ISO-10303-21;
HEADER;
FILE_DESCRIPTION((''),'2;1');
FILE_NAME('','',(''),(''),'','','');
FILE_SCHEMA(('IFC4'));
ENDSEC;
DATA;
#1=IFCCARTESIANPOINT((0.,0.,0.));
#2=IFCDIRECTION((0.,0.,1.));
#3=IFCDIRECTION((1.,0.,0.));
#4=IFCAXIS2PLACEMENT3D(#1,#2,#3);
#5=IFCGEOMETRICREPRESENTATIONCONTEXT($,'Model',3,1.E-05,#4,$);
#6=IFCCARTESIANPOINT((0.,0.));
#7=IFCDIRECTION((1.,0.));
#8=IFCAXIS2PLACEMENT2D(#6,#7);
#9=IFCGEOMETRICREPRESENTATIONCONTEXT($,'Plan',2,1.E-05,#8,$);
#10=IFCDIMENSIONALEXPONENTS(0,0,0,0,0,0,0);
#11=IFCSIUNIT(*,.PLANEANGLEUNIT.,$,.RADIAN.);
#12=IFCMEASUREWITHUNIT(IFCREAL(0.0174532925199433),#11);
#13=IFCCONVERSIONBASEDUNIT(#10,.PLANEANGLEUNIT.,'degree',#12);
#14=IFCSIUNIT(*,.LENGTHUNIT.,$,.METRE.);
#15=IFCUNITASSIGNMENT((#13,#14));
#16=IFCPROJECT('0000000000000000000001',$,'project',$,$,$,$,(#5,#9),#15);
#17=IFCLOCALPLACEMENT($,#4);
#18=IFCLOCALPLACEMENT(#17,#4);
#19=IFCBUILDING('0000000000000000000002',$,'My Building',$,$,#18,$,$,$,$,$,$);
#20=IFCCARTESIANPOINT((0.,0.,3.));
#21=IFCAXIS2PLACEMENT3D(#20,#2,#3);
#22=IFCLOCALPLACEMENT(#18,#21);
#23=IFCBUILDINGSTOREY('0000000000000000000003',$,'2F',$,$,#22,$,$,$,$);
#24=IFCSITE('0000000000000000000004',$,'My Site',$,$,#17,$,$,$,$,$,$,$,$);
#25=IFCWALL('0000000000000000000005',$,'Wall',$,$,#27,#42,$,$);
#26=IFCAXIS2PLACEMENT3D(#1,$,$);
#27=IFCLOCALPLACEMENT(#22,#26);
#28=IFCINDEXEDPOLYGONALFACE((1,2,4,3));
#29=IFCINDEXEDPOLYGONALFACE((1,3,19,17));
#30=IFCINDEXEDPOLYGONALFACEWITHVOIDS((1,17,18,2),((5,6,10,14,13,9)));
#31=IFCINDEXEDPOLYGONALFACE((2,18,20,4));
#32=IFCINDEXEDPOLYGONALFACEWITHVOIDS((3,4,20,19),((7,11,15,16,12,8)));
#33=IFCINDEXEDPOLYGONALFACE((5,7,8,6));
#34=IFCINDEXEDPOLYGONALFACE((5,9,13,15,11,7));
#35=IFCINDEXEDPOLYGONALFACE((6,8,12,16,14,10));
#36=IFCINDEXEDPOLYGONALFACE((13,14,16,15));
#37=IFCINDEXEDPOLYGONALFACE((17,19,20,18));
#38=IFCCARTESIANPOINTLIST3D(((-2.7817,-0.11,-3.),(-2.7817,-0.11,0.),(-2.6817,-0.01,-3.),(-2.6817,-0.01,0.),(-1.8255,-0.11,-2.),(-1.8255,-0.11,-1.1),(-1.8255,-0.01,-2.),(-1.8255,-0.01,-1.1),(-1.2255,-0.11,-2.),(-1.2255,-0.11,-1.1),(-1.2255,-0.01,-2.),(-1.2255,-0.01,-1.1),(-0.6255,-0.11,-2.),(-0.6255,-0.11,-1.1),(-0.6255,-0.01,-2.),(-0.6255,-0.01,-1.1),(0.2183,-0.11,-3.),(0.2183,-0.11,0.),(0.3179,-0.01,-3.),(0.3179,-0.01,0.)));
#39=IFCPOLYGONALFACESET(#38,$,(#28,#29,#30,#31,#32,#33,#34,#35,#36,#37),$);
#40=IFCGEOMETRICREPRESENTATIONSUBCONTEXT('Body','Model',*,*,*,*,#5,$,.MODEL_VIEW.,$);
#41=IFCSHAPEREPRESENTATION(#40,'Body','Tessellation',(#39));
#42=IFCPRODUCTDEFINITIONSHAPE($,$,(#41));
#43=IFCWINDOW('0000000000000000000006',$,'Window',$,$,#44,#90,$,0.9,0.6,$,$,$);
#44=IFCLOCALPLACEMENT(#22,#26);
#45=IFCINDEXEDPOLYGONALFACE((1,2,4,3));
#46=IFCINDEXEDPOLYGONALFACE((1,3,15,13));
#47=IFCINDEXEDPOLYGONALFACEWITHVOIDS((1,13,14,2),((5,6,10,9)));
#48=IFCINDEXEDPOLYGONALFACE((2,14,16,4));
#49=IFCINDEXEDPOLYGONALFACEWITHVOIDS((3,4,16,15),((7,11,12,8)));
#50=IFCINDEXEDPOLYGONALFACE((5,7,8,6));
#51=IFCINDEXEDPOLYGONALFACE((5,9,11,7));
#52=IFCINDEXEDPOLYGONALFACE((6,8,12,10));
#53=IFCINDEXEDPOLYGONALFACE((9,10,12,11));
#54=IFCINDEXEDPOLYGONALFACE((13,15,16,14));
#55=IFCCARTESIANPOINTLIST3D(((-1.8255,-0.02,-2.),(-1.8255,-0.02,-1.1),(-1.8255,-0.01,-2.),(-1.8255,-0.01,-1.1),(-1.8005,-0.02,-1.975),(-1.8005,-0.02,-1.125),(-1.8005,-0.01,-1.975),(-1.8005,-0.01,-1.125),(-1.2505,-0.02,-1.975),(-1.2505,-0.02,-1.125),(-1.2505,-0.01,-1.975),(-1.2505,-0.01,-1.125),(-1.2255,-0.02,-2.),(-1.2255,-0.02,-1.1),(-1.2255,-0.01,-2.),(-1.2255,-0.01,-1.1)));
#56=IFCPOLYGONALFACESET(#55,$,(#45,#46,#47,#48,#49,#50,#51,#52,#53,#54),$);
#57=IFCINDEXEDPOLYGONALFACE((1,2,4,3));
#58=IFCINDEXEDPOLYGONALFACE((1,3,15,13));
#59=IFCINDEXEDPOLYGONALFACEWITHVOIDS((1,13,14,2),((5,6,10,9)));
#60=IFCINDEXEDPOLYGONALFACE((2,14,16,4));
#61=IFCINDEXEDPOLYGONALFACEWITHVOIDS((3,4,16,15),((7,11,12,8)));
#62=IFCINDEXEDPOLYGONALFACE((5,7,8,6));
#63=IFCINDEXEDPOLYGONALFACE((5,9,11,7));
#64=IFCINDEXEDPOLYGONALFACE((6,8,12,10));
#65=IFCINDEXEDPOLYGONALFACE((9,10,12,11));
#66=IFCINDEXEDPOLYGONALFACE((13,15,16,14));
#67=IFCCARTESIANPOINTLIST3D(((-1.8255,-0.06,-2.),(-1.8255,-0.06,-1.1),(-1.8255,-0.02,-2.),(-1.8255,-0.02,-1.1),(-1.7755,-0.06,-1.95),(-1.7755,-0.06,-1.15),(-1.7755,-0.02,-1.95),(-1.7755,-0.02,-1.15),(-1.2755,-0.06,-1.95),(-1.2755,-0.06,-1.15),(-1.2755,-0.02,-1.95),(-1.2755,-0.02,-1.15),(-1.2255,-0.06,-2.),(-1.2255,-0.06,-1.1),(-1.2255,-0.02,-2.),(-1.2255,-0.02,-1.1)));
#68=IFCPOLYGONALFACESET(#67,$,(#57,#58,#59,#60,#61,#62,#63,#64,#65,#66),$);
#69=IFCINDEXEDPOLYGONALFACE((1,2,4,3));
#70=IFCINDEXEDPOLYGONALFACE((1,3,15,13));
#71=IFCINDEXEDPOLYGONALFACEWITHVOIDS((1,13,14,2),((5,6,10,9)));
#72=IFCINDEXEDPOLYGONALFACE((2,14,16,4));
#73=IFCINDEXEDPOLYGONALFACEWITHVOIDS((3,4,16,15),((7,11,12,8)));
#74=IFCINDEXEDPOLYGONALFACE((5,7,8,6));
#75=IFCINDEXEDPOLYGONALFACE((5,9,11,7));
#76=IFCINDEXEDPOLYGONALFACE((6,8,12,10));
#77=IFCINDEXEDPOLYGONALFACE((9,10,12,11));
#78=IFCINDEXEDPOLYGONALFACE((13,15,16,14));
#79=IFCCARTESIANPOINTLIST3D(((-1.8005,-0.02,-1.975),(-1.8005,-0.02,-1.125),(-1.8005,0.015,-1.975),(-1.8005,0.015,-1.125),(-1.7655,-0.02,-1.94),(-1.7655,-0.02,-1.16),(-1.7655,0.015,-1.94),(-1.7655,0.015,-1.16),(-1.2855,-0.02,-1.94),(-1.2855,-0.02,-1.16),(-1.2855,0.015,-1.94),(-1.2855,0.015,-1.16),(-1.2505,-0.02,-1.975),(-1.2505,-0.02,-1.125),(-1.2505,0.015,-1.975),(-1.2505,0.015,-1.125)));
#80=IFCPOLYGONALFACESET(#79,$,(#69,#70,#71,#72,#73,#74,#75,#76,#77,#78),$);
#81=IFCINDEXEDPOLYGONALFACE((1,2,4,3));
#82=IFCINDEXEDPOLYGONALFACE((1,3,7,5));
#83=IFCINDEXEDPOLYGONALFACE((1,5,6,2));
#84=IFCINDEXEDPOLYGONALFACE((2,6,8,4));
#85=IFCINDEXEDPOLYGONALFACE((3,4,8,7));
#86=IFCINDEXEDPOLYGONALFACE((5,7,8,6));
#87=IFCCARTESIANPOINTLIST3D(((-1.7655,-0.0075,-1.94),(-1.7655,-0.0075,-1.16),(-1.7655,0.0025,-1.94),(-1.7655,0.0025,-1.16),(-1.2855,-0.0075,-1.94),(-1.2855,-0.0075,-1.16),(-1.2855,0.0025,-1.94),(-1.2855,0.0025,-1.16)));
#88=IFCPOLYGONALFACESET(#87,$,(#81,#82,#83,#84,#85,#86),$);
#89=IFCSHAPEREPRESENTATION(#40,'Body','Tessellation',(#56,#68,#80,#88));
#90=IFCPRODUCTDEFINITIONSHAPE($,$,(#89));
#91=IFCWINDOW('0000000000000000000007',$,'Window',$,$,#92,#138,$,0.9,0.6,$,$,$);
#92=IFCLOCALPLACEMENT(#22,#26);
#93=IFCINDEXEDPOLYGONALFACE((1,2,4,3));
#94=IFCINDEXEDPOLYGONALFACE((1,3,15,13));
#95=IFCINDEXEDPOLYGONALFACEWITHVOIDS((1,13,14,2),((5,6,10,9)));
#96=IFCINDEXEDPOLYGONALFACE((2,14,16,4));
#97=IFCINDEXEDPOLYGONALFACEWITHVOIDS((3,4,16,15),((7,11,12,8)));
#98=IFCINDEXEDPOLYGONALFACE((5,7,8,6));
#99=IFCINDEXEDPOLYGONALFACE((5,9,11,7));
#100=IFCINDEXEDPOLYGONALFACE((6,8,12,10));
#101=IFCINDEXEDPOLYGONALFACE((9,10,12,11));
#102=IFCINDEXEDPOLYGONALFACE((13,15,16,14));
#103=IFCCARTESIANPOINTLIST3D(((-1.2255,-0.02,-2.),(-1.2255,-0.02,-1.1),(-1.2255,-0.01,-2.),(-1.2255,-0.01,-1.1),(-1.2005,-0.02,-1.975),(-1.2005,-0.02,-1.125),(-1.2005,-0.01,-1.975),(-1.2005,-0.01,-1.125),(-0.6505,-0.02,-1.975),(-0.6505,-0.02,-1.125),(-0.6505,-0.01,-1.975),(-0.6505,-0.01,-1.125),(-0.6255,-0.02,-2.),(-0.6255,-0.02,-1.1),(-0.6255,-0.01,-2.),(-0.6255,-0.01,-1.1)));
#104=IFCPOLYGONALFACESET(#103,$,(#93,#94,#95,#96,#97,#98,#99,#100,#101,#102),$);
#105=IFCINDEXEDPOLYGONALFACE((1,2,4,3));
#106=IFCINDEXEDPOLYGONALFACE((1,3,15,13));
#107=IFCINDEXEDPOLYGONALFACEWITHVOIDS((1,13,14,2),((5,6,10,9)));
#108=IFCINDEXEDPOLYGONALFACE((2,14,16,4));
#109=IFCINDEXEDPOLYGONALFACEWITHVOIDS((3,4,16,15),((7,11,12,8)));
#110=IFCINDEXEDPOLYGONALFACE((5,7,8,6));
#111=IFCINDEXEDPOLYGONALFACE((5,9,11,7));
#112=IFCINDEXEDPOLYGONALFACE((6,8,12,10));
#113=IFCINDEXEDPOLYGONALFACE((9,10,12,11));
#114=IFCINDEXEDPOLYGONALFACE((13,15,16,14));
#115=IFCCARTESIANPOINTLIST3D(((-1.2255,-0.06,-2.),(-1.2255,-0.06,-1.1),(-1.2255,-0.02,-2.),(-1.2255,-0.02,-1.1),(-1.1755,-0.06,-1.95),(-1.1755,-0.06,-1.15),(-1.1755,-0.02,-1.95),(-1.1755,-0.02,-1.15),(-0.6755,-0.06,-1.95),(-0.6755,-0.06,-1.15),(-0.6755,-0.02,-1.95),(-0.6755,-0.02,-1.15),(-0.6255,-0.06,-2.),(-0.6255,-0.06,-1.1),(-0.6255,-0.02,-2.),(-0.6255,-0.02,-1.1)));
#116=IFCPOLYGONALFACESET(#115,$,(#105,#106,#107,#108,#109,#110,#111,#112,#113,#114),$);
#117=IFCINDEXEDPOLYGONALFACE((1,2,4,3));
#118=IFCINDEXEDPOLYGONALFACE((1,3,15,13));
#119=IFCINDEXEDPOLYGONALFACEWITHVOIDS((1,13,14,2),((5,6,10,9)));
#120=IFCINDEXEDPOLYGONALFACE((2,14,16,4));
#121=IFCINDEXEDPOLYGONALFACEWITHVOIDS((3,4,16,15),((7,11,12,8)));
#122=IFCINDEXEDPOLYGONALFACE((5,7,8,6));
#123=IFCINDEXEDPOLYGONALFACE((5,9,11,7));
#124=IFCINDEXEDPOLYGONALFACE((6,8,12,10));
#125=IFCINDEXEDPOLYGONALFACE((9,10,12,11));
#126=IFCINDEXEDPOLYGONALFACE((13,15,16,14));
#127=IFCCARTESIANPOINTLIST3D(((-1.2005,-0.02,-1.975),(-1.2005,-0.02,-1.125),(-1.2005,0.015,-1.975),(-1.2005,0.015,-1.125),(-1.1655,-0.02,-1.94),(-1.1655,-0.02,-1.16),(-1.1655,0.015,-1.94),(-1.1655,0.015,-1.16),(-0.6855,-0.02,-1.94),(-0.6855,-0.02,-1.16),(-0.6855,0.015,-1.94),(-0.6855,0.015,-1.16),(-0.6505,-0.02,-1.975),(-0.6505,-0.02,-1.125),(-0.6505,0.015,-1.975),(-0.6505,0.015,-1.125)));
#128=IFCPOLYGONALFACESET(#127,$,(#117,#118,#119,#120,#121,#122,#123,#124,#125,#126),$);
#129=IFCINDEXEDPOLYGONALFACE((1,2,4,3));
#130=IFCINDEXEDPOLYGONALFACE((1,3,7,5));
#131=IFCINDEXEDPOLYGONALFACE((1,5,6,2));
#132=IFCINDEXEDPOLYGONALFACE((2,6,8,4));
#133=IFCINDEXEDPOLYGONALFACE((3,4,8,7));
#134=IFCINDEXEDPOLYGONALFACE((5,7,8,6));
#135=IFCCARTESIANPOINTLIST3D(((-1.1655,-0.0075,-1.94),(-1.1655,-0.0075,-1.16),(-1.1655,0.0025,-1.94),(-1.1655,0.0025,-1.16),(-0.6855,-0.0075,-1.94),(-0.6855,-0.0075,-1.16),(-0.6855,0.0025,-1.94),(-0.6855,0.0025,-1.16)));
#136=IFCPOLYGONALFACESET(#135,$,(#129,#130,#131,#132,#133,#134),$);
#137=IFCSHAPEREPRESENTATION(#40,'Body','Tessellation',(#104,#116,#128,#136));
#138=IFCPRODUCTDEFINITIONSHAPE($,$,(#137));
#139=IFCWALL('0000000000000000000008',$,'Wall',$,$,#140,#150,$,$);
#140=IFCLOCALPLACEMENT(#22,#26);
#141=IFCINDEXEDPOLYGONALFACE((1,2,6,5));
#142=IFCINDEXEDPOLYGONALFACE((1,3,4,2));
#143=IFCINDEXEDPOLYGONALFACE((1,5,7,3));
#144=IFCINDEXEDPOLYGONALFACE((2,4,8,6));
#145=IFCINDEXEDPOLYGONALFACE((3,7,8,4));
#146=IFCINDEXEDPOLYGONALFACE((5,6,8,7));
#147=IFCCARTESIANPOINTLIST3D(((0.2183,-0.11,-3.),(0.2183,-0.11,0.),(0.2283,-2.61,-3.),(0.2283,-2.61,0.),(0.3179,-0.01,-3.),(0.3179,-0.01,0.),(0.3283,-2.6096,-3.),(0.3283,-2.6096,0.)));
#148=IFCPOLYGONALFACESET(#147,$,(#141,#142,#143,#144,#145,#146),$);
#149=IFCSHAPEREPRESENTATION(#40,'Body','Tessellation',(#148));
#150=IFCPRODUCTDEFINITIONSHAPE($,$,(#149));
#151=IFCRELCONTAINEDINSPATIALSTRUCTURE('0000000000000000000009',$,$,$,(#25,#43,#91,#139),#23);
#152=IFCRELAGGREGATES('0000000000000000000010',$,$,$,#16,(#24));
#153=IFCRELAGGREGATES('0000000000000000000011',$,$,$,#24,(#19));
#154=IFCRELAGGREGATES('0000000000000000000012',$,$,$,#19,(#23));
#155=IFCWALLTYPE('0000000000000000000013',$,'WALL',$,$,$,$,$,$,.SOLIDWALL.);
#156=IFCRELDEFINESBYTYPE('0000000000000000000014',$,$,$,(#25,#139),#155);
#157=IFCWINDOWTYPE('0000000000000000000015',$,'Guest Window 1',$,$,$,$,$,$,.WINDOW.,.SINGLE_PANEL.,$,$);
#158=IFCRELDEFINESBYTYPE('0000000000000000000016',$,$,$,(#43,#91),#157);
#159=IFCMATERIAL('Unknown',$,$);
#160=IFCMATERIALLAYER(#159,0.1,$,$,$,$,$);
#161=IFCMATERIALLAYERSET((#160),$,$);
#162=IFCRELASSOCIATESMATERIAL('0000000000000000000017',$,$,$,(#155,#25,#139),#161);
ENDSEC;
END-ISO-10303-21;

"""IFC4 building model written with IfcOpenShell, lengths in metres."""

from ifc_helpers import new_model, entity, si_unit, converted_unit, frame, origin_with_axes, origin_2d_with_axis, place, context, subcontext, project, spatial, line, indexed_curve, outline, extrude, shape, source, transform, mapped, material, layer, layer_set, layer_usage, type_object, type_shapes, element, fill, save


model = new_model("IFC4")

# Units and contexts
model_context = context("Model", 3, precision=1e-05, world=origin_with_axes())
plan_context = context("Plan", 2, precision=1e-05, world=origin_2d_with_axis())
body_context_1 = subcontext(model_context, "Body", "Model", "MODEL_VIEW")
body_context_2 = subcontext(plan_context, "Body", "Plan", "PLAN_VIEW")
ifc_project = project(units=[converted_unit("PLANEANGLEUNIT", "degree", entity("IfcReal", 0.0174532925199433), si_unit("PLANEANGLEUNIT", "RADIAN"), dimensions=[0, 0, 0, 0, 0, 0, 0]), si_unit("LENGTHUNIT", "METRE")], contexts=[model_context, plan_context])

# Site, building, storey
site_placement = place(None, origin_with_axes())
site = spatial("IfcSite", under=ifc_project, at=site_placement, Name="My Site")
building_placement = place(site_placement, origin_with_axes())
building = spatial("IfcBuilding", under=site, at=building_placement, Name="My Building")
storey_placement = place(building_placement, frame((0.0, 0.0, 3.0), z_axis=(0.0, 0.0, 1.0), x_axis=(1.0, 0.0, 0.0)))
storey = spatial("IfcBuildingStorey", under=building, at=storey_placement, Name="2F")

# Shared definitions
ifc_material = material(Name="Unknown")
ifc_layer_1 = layer(ifc_material, 0.1)
ifc_layer_set_1 = layer_set([ifc_layer_1])
wall_type_1 = type_object("IfcWallType", Name="WALL", PredefinedType="SOLIDWALL", material=ifc_layer_set_1)

# Wall, openings, windows
ifc_layer_usage_1 = layer_usage(ifc_layer_set_1, "AXIS2", "POSITIVE", 0.0)
wall_1_placement = place(storey_placement, frame((-2.7817, -0.11, -3.0), z_axis=(0.0, 0.0, 1.0), x_axis=(1.0, 0.0, 0.0)))
wall_1 = element("IfcWall", 1, at=wall_1_placement, inside=storey, type_object=wall_type_1, material=ifc_layer_usage_1, Name="Wall", context=body_context_1, shape_type="SweptSolid", body=[
    extrude(outline(indexed_curve([(0.0, 0.0), (0.1, 0.1), (3.0996, 0.1), (3.0, 0.0)], segments=[line(1, 2, 3, 4, 1)])), origin_with_axes(), (0.0, 0.0, 1.0), 3.0),
])
shared_shape_1 = source(origin_with_axes(), body_context_1, "Body", "SweptSolid", [
    extrude(outline(indexed_curve([(0.0, 0.0), (0.6, 0.0), (0.6, 0.9), (0.0, 0.9)], segments=[line(1, 2, 3, 4, 1)])), frame((0.0, -0.6, 0.0), z_axis=(0.0, -1.0, 0.0), x_axis=(1.0, 0.0, 0.0)), (0.0, 0.0, -1.0), 1.2),
])
opening_1_placement = place(wall_1_placement, frame((0.9562, 0.0, 1.0), z_axis=(0.0, 0.0, 1.0), x_axis=(1.0, 0.0, 0.0)))
opening_1 = element("IfcOpeningElement", 2, at=opening_1_placement, cuts=wall_1, PredefinedType="OPENING", context=body_context_1, shape_type="MappedRepresentation", body=[
    mapped(shared_shape_1, transform((0.0, 0.0, 0.0), x_axis=(1.0, 0.0, 0.0), y_axis=(0.0, 1.0, 0.0), z_axis=(0.0, 0.0, 1.0), scale=1.0)),
])
opening_2_placement = place(wall_1_placement, frame((1.5562, 0.0, 1.0), z_axis=(0.0, 0.0, 1.0), x_axis=(1.0, 0.0, 0.0)))
opening_2 = element("IfcOpeningElement", 3, at=opening_2_placement, cuts=wall_1, PredefinedType="OPENING", context=body_context_1, shape_type="MappedRepresentation", body=[
    mapped(shared_shape_1, transform((0.0, 0.0, 0.0), x_axis=(1.0, 0.0, 0.0), y_axis=(0.0, 1.0, 0.0), z_axis=(0.0, 0.0, 1.0), scale=1.0)),
])
window_type_1 = type_object("IfcWindowType", Name="Guest Window 1", PartitioningType="SINGLE_PANEL", PredefinedType="WINDOW")
shared_shape_2 = source(origin_with_axes(), body_context_1, "Body", "SweptSolid", [
    extrude(outline(indexed_curve([(0.0, 0.0), (0.6, 0.0), (0.6, 0.9), (0.0, 0.9)], segments=[line(1, 2, 3, 4, 1)]), holes=[indexed_curve([(0.025, 0.025), (0.575, 0.025), (0.575, 0.875), (0.025, 0.875)], segments=[line(1, 2, 3, 4, 1)])]), frame((0.0, 0.09, 0.0), z_axis=(0.0, -1.0, 0.0), x_axis=(1.0, 0.0, 0.0)), (0.0, 0.0, -1.0), 0.01),
    extrude(outline(indexed_curve([(0.0, 0.0), (0.6, 0.0), (0.6, 0.9), (0.0, 0.9)], segments=[line(1, 2, 3, 4, 1)]), holes=[indexed_curve([(0.05, 0.05), (0.55, 0.05), (0.55, 0.85), (0.05, 0.85)], segments=[line(1, 2, 3, 4, 1)])]), frame((0.0, 0.05, 0.0), z_axis=(0.0, -1.0, 0.0), x_axis=(1.0, 0.0, 0.0)), (0.0, 0.0, -1.0), 0.04),
    extrude(outline(indexed_curve([(0.0, 0.0), (0.55, 0.0), (0.55, 0.85), (0.0, 0.85)], segments=[line(1, 2, 3, 4, 1)]), holes=[indexed_curve([(0.035, 0.035), (0.515, 0.035), (0.515, 0.815), (0.035, 0.815)], segments=[line(1, 2, 3, 4, 1)])]), frame((0.025, 0.09, 0.025), z_axis=(0.0, -1.0, 0.0), x_axis=(1.0, 0.0, 0.0)), (0.0, 0.0, -1.0), 0.035),
    extrude(outline(indexed_curve([(0.035, 0.035), (0.515, 0.035), (0.515, 0.815), (0.035, 0.815)], segments=[line(1, 2, 3, 4, 1)])), frame((0.025, 0.1025, 0.025), z_axis=(0.0, -1.0, 0.0), x_axis=(1.0, 0.0, 0.0)), (0.0, 0.0, -1.0), 0.01),
])
shared_shape_3 = source(origin_with_axes(), body_context_2, "Body", "Curve2D", [
    entity("IfcIndexedPolyCurve", entity("IfcCartesianPointList2D", [[0.05, 0.05], [0.55, 0.05]])),
    entity("IfcIndexedPolyCurve", entity("IfcCartesianPointList2D", [[0.0, 0.1], [0.025, 0.1], [0.025, 0.09], [0.05, 0.09], [0.05, 0.05], [0.0, 0.05]]), [entity("IfcLineIndex", [1, 2, 3, 4, 5, 6, 1])]),
    entity("IfcIndexedPolyCurve", entity("IfcCartesianPointList2D", [[0.6, 0.1], [0.575, 0.1], [0.575, 0.09], [0.55, 0.09], [0.55, 0.05], [0.6, 0.05]]), [entity("IfcLineIndex", [1, 2, 3, 4, 5, 6, 1])]),
    entity("IfcIndexedPolyCurve", entity("IfcCartesianPointList2D", [[0.025, 0.09], [0.06, 0.09], [0.06, 0.125], [0.025, 0.125]]), [entity("IfcLineIndex", [1, 2, 3, 4, 1])]),
    entity("IfcIndexedPolyCurve", entity("IfcCartesianPointList2D", [[0.575, 0.09], [0.54, 0.09], [0.54, 0.125], [0.575, 0.125]]), [entity("IfcLineIndex", [1, 2, 3, 4, 1])]),
    entity("IfcIndexedPolyCurve", entity("IfcCartesianPointList2D", [[0.06, 0.09], [0.54, 0.09]])),
    entity("IfcIndexedPolyCurve", entity("IfcCartesianPointList2D", [[0.06, 0.125], [0.54, 0.125]])),
    entity("IfcIndexedPolyCurve", entity("IfcCartesianPointList2D", [[0.06, 0.1075], [0.54, 0.1075]])),
])
type_shapes(window_type_1, [shared_shape_2, shared_shape_3])
window_1_placement = place(opening_1_placement, origin_with_axes())
window_1 = element("IfcWindow", 4, at=window_1_placement, inside=storey, type_object=window_type_1, Name="Window", OverallHeight=0.9, OverallWidth=0.6, shapes=[
    shape(body_context_1, "Body", "MappedRepresentation", [mapped(shared_shape_2, transform((0.0, 0.0, 0.0), x_axis=(1.0, 0.0, 0.0), y_axis=(0.0, 1.0, 0.0), z_axis=(0.0, 0.0, 1.0), scale=1.0))]),
    shape(body_context_2, "Body", "MappedRepresentation", [mapped(shared_shape_3, transform((0.0, 0.0, 0.0), x_axis=(1.0, 0.0, 0.0), y_axis=(0.0, 1.0, 0.0), z_axis=(0.0, 0.0, 1.0), scale=1.0))]),
])
fill(opening_1, window_1)
window_2_placement = place(opening_2_placement, origin_with_axes())
window_2 = element("IfcWindow", 5, at=window_2_placement, inside=storey, type_object=window_type_1, Name="Window", OverallHeight=0.9, OverallWidth=0.6, shapes=[
    shape(body_context_1, "Body", "MappedRepresentation", [mapped(shared_shape_2, transform((0.0, 0.0, 0.0), x_axis=(1.0, 0.0, 0.0), y_axis=(0.0, 1.0, 0.0), z_axis=(0.0, 0.0, 1.0), scale=1.0))]),
    shape(body_context_2, "Body", "MappedRepresentation", [mapped(shared_shape_3, transform((0.0, 0.0, 0.0), x_axis=(1.0, 0.0, 0.0), y_axis=(0.0, 1.0, 0.0), z_axis=(0.0, 0.0, 1.0), scale=1.0))]),
])
fill(opening_2, window_2)

# Wall
ifc_layer_usage_2 = layer_usage(ifc_layer_set_1, "AXIS2", "POSITIVE", 0.0)
wall_2_placement = place(storey_placement, frame((0.2183, -0.11, -3.0), z_axis=(0.0, 0.0, 1.0), x_axis=(0.004, -0.999992, 0.0)))
element("IfcWall", 6, at=wall_2_placement, inside=storey, type_object=wall_type_1, material=ifc_layer_usage_2, Name="Wall", context=body_context_1, shape_type="SweptSolid", body=[
    extrude(outline(indexed_curve([(0.0, 0.0), (-0.0996, 0.1), (2.5, 0.1), (2.5, 0.0)], segments=[line(1, 2, 3, 4, 1)])), origin_with_axes(), (0.0, 0.0, 1.0), 3.0),
])

save(model, "model.ifc")
